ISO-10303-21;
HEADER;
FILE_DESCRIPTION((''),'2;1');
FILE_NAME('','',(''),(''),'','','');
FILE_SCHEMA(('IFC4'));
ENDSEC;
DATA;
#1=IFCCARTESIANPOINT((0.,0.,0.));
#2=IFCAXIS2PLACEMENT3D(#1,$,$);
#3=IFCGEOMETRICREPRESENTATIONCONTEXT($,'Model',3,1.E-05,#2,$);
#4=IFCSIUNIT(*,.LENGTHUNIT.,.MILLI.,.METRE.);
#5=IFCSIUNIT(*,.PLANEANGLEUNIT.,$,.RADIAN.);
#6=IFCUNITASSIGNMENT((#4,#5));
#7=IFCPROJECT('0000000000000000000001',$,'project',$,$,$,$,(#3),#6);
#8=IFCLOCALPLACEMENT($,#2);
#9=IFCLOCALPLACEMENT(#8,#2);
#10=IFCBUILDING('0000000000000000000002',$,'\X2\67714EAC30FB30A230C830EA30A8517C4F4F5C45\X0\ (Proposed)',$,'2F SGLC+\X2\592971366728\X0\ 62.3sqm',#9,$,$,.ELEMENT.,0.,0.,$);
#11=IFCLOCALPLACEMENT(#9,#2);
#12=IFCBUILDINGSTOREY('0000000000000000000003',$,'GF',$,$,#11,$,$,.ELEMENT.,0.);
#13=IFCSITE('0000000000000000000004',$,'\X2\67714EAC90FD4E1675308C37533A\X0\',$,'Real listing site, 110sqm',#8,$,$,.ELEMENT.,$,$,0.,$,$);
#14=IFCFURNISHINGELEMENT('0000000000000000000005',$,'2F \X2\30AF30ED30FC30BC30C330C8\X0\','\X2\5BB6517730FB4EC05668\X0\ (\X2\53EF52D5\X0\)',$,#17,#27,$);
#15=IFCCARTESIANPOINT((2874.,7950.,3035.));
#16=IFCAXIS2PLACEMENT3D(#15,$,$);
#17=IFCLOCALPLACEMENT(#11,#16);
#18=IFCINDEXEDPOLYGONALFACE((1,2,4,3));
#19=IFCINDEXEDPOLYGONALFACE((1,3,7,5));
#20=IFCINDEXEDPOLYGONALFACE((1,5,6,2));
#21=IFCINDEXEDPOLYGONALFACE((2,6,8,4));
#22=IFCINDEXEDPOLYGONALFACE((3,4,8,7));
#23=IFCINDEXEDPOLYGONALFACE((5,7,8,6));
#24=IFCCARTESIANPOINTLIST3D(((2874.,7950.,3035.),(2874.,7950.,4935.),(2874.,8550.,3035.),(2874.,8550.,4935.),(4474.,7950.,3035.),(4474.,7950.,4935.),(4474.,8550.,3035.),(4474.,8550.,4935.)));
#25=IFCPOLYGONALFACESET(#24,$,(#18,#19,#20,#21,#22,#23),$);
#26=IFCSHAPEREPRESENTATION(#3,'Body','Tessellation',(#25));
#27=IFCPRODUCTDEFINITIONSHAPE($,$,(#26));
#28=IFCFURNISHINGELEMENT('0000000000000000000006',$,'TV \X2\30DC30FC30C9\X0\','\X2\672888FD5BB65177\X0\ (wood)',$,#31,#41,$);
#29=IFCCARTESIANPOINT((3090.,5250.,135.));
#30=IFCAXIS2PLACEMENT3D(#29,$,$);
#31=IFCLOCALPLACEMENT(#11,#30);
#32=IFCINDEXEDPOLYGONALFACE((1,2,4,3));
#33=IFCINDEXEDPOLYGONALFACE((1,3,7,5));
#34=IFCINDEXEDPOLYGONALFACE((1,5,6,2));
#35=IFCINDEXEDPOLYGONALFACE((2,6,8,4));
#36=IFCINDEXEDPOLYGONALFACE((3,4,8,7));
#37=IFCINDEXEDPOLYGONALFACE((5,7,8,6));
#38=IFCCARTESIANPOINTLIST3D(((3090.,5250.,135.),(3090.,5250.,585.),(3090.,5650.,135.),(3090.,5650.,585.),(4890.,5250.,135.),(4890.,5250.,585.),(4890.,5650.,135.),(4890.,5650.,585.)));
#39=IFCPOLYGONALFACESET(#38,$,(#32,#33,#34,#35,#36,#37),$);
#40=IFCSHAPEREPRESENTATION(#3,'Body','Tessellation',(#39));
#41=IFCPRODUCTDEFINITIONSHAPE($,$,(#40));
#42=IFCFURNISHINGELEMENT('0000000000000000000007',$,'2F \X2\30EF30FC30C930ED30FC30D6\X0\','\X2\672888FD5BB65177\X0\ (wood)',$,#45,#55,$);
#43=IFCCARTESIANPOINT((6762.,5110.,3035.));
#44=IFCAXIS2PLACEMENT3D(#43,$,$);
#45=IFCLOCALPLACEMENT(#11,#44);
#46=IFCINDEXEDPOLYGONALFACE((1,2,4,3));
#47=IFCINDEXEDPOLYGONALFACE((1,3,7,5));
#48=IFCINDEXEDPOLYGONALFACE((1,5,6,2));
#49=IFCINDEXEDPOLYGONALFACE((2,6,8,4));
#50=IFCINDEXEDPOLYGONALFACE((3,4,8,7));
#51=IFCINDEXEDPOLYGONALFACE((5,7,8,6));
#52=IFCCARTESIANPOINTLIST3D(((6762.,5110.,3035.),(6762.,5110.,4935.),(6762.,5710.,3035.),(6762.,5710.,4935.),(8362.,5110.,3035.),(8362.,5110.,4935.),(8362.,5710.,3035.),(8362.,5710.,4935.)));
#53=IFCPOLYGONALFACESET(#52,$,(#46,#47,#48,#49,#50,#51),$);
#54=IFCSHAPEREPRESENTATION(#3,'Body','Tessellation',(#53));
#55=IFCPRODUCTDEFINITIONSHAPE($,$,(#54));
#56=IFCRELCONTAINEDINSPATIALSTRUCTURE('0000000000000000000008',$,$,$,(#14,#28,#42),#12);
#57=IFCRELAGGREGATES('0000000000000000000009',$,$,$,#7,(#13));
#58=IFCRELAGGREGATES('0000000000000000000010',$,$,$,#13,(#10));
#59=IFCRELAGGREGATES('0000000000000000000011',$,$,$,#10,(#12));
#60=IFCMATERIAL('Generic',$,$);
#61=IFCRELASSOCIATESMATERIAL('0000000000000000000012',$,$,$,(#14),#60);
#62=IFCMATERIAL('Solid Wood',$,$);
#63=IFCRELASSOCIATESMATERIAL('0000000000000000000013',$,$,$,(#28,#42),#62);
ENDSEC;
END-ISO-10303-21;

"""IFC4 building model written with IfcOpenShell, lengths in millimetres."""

from ifc_helpers import new_model, si_unit, frame, frame_2d, origin, place, context, project, spatial, rectangle, extrude, material, element, save


model = new_model("IFC4")

# Units and contexts
model_context = context("Model", 3, precision=1e-05, world=origin())
ifc_project = project(units=[si_unit("LENGTHUNIT", "METRE", prefix="MILLI"), si_unit("PLANEANGLEUNIT", "RADIAN")], contexts=[model_context])

# Site, building, storey
site_placement = place(None, origin())
site = spatial("IfcSite", under=ifc_project, at=site_placement, Name="東京都世田谷区", ObjectType="Real listing site, 110sqm", CompositionType="ELEMENT", RefElevation=0.0)
building_placement = place(site_placement, origin())
building = spatial("IfcBuilding", under=site, at=building_placement, Name="東京・アトリエ兼住居 (Proposed)", ObjectType="2F SGLC+天然木 62.3sqm", CompositionType="ELEMENT", ElevationOfRefHeight=0.0, ElevationOfTerrain=0.0)
storey_placement = place(building_placement, origin())
storey = spatial("IfcBuildingStorey", under=building, at=storey_placement, Name="GF", CompositionType="ELEMENT", Elevation=0.0)

# Shared definitions
ifc_material_1 = material(Name="Solid Wood")

# Shared definitions
ifc_material_2 = material(Name="Generic")

# Furnishing elements
furnishing_1_placement = place(storey_placement, frame((2874.0, 7950.0, 3035.0)))
element("IfcFurnishingElement", 1, at=furnishing_1_placement, inside=storey, material=ifc_material_2, Name="2F クローゼット", Description="家具・什器 (可動)", context=model_context, shape_type="SweptSolid", body=[
    extrude(rectangle(XDim=1600.0, YDim=600.0, at=frame_2d((800.0, 300.0))), frame((2874.0, 7950.0, 3035.0)), (0.0, 0.0, 1.0), 1900.0),
])
furnishing_2_placement = place(storey_placement, frame((3090.0, 5250.0, 135.0)))
element("IfcFurnishingElement", 2, at=furnishing_2_placement, inside=storey, material=ifc_material_1, Name="TV ボード", Description="木製家具 (wood)", context=model_context, shape_type="SweptSolid", body=[
    extrude(rectangle(XDim=1800.0, YDim=400.0, at=frame_2d((900.0, 200.0))), frame((3090.0, 5250.0, 135.0)), (0.0, 0.0, 1.0), 450.0),
])
furnishing_3_placement = place(storey_placement, frame((6762.0, 5110.0, 3035.0)))
element("IfcFurnishingElement", 3, at=furnishing_3_placement, inside=storey, material=ifc_material_1, Name="2F ワードローブ", Description="木製家具 (wood)", context=model_context, shape_type="SweptSolid", body=[
    extrude(rectangle(XDim=1600.0, YDim=600.0, at=frame_2d((800.0, 300.0))), frame((6762.0, 5110.0, 3035.0)), (0.0, 0.0, 1.0), 1900.0),
])

save(model, "model.ifc")
